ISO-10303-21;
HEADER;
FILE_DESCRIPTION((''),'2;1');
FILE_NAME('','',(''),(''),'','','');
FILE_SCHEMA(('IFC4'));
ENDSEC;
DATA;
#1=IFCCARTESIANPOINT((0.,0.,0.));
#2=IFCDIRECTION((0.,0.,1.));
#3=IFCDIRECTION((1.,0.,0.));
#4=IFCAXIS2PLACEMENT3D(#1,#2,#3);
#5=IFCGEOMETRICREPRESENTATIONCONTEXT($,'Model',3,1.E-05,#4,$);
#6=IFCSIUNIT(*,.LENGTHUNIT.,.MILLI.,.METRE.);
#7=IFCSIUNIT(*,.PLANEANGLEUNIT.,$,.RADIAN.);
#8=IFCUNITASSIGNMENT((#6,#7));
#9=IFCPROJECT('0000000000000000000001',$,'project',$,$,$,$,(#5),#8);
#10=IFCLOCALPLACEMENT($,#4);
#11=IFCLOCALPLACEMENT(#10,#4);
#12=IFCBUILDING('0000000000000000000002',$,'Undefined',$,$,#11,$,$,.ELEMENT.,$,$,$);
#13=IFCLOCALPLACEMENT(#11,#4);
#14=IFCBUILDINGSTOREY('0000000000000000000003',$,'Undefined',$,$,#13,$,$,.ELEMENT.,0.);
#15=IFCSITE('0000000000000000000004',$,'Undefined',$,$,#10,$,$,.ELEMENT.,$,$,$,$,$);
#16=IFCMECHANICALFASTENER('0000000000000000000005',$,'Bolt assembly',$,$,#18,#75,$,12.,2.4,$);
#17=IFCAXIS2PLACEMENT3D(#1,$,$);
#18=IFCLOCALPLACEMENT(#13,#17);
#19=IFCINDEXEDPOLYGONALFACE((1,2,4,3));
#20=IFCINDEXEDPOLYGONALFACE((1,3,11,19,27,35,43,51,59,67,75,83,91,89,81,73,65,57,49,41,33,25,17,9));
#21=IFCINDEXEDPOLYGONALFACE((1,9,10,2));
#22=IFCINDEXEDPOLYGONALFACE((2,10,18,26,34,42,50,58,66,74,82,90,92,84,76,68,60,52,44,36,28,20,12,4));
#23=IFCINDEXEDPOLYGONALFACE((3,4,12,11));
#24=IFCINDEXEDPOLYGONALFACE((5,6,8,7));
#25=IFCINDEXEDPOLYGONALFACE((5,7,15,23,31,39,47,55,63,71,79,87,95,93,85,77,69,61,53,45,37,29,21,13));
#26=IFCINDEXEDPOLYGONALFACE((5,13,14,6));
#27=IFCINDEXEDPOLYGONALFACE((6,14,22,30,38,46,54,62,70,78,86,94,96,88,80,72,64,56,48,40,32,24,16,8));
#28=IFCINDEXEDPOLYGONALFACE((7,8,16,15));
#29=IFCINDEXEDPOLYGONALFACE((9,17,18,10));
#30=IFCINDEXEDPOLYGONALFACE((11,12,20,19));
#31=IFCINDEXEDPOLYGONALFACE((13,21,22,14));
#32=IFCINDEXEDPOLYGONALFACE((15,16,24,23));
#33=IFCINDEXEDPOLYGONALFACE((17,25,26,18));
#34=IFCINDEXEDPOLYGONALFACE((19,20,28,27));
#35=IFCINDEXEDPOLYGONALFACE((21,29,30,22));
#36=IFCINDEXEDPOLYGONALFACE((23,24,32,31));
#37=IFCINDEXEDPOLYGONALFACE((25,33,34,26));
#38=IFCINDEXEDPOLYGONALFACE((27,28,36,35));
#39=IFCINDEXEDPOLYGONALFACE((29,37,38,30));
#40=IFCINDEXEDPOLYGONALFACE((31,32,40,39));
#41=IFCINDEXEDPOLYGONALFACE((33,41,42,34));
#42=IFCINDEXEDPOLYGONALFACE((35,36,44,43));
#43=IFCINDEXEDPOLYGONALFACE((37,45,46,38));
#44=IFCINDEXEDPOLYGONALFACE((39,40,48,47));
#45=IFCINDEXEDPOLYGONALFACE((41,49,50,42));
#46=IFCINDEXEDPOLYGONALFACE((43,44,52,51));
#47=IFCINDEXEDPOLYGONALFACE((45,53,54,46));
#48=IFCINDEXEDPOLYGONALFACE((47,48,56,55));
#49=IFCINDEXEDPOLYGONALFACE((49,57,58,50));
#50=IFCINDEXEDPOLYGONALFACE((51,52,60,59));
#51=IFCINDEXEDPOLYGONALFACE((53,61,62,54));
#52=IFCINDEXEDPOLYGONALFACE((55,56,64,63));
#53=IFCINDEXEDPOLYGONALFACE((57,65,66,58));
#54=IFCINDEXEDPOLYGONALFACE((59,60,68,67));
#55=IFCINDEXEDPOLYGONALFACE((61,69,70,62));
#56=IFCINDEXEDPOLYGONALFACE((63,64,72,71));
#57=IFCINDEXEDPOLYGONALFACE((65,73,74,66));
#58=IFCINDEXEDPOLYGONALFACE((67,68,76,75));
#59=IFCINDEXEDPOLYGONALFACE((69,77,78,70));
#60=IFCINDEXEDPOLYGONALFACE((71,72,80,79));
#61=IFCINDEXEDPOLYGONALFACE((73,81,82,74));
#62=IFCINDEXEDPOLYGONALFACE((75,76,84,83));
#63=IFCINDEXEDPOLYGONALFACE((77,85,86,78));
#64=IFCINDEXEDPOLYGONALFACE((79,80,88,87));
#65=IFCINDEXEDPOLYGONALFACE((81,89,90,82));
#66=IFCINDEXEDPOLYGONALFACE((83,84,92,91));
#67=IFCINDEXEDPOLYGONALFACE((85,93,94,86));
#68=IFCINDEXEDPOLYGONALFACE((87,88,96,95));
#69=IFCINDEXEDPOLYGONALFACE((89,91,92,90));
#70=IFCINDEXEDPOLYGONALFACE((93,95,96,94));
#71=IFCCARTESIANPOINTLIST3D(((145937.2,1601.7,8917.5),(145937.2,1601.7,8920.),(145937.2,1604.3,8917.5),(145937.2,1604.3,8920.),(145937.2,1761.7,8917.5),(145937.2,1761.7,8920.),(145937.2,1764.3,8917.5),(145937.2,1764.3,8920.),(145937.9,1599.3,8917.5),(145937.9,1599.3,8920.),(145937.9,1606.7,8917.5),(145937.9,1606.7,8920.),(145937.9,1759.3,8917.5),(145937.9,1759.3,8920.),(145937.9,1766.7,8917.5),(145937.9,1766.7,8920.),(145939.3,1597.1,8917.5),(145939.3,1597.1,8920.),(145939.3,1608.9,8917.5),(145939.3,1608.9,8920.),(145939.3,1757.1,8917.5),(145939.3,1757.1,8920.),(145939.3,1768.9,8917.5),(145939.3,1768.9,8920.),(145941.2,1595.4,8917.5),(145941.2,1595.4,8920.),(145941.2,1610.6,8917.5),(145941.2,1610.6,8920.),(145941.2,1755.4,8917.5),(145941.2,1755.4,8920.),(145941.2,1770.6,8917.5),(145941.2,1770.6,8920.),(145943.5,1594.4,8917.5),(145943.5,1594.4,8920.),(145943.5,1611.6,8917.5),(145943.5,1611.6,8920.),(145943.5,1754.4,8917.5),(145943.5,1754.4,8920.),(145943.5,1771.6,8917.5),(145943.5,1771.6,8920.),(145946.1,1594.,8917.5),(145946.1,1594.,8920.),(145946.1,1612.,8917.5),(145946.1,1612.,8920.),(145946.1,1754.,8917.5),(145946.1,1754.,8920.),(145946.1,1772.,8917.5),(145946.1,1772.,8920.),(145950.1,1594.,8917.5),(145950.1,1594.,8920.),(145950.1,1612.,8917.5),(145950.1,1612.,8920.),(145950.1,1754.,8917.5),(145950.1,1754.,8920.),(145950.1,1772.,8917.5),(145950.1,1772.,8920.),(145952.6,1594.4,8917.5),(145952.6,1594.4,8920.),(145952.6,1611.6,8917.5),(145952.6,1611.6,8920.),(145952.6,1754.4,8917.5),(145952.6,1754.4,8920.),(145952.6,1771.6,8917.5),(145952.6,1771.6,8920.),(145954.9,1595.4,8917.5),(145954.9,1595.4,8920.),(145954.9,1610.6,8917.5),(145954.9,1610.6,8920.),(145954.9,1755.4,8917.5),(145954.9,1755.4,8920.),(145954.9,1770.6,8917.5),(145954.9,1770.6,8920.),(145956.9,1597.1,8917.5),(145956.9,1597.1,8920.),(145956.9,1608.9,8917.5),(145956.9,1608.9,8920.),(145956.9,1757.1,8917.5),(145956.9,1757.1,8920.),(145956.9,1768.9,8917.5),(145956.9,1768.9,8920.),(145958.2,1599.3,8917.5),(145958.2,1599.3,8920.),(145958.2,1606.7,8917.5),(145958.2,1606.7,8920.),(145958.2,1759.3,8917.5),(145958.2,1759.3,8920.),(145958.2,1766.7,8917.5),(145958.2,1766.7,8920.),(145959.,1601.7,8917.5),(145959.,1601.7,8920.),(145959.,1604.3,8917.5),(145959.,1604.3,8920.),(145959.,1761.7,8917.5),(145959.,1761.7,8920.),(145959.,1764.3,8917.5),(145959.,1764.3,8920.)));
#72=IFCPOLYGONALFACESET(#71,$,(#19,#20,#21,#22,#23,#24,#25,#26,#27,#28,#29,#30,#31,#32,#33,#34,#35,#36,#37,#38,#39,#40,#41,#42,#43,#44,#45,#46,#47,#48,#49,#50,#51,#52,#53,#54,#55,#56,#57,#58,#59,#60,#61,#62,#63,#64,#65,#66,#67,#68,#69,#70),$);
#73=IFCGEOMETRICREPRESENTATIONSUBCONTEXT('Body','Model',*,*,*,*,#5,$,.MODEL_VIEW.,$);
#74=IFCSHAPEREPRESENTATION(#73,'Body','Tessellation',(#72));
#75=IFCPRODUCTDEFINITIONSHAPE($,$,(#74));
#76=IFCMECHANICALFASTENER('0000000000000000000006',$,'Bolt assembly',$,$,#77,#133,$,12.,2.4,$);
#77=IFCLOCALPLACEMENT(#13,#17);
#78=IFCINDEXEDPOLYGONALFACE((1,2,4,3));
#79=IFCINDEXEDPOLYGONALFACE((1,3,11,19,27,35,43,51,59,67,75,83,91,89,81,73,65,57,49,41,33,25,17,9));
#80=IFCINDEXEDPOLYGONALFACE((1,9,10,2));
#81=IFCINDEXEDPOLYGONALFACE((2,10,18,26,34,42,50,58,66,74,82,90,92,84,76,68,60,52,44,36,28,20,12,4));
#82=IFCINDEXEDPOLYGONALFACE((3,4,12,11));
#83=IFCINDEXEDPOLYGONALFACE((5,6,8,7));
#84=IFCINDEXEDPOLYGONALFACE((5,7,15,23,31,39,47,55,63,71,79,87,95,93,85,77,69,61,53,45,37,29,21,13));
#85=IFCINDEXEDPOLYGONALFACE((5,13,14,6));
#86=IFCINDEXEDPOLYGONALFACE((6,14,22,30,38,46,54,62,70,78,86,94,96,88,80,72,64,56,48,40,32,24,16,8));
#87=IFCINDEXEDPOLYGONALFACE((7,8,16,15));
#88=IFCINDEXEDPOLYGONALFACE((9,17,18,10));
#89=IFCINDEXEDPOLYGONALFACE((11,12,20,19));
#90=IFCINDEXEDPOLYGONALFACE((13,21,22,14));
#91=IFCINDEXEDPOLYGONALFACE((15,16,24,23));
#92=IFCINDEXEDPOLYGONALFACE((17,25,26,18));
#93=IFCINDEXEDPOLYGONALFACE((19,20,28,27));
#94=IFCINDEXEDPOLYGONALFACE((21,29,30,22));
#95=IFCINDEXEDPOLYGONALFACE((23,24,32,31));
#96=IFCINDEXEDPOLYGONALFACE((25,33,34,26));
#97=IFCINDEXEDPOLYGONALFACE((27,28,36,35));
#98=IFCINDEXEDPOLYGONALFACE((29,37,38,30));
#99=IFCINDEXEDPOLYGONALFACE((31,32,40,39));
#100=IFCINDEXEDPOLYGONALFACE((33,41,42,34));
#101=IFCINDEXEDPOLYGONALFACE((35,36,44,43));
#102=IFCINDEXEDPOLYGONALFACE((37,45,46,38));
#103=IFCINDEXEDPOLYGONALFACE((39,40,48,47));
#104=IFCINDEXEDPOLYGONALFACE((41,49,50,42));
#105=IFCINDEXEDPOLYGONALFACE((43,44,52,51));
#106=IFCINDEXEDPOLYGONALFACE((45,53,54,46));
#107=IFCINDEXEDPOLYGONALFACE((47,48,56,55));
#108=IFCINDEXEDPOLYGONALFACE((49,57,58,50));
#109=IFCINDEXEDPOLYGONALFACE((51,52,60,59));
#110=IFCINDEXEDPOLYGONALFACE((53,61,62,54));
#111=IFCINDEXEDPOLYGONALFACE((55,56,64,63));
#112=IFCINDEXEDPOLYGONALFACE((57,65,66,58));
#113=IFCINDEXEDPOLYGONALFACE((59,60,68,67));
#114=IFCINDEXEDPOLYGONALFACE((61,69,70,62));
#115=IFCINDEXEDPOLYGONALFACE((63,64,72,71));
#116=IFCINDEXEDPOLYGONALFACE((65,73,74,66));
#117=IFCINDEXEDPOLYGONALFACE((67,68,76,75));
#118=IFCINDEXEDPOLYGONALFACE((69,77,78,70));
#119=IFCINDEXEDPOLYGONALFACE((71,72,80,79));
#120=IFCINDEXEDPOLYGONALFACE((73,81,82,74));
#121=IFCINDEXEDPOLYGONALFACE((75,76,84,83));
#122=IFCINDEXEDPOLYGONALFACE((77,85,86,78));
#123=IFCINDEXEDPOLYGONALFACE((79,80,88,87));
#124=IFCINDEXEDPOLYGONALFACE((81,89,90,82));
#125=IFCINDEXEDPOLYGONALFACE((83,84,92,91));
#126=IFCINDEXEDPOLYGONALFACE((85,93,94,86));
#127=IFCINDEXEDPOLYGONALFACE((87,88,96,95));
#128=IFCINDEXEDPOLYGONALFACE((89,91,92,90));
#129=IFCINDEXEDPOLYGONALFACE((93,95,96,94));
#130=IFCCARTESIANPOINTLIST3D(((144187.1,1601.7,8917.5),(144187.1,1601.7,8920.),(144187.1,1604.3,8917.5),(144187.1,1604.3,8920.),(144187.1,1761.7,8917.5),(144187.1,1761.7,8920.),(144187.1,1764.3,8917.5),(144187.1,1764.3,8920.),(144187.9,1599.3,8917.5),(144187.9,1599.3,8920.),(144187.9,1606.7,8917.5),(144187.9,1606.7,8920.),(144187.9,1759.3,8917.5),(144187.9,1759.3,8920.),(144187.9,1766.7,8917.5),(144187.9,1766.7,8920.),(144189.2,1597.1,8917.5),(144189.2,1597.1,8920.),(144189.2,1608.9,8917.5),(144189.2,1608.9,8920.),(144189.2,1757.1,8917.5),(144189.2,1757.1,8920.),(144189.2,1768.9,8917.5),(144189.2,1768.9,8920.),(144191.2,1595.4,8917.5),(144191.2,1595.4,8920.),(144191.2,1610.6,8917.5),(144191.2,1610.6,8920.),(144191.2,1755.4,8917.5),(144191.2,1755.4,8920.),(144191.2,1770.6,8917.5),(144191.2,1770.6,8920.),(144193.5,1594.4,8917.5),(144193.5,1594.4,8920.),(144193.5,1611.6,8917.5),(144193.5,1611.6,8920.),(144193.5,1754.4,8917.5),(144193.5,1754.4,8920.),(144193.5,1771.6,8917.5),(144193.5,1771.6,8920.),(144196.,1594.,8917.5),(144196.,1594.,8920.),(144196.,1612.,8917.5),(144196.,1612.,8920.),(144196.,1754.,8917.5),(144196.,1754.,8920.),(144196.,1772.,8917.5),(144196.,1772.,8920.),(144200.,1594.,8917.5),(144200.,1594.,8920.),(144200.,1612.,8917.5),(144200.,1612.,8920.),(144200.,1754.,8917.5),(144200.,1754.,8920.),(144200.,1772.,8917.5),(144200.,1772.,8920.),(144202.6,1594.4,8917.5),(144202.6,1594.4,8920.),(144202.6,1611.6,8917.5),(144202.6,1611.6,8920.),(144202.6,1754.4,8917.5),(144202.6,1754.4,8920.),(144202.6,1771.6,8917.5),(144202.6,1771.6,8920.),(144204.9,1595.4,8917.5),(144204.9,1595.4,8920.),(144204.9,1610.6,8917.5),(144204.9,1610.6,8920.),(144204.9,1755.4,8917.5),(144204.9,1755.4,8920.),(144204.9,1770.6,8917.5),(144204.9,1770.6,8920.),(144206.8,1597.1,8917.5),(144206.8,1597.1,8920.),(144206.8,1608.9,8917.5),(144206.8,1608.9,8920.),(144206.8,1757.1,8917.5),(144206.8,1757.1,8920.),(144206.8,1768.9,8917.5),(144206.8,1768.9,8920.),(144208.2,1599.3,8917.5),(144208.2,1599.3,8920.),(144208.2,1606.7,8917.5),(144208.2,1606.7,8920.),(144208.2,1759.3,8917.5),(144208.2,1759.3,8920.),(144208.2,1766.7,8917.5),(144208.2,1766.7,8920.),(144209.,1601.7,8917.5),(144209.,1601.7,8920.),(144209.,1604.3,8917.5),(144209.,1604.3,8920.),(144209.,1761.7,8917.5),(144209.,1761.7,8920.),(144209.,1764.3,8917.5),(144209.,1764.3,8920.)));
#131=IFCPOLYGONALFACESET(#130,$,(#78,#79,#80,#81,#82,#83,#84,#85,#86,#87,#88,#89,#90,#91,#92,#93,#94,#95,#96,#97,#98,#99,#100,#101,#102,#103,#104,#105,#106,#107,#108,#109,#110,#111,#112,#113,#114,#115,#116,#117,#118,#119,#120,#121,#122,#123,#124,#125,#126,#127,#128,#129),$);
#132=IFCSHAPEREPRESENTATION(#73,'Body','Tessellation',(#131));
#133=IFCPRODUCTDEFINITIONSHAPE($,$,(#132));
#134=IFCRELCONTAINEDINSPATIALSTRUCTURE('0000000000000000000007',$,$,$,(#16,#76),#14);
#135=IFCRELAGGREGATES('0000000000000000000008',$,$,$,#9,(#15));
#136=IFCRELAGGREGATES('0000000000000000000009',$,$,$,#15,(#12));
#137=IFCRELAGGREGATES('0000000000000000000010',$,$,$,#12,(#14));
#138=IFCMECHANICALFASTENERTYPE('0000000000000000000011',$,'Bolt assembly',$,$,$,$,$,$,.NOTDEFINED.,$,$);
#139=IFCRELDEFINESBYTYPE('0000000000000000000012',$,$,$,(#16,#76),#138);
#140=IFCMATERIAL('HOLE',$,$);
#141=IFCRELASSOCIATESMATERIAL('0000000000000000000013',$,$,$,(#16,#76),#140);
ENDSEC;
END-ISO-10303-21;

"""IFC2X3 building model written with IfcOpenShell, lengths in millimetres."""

from ifc_helpers import new_model, si_unit, frame, frame_2d, origin_with_axes, place, context, subcontext, project, spatial, polyline, circle_curve, parameter, trimmed, segment, composite_curve, outline, extrude, source, transform, mapped, material, type_object, element, save


model = new_model("IFC2X3")

# Units and contexts
model_context = context("Model", 3, precision=1e-05, world=origin_with_axes())
body_context = subcontext(model_context, "Body", "Model", "MODEL_VIEW")
ifc_project = project(units=[si_unit("LENGTHUNIT", "METRE", prefix="MILLI"), si_unit("PLANEANGLEUNIT", "RADIAN")], contexts=[model_context])

# Site, building, storey
site_placement = place(None, origin_with_axes())
site = spatial("IfcSite", under=ifc_project, at=site_placement, Name="Undefined", CompositionType="ELEMENT")
building_placement = place(site_placement, origin_with_axes())
building = spatial("IfcBuilding", under=site, at=building_placement, Name="Undefined", CompositionType="ELEMENT")
storey_placement = place(building_placement, origin_with_axes())
storey = spatial("IfcBuildingStorey", under=building, at=storey_placement, Name="Undefined", CompositionType="ELEMENT", Elevation=0.0)

# Mechanical fasteners
mechanical_fastener_type = type_object("IfcMechanicalFastenerType", Name="Bolt assembly")
ifc_material_1 = material(Name="HOLE")
shared_shape_1 = source(origin_with_axes(), body_context, "Body", "SweptSolid", [
    extrude(outline(composite_curve([segment(polyline([(-2.0, 9.0), (2.0, 9.0)]), True, "CONTINUOUS"), segment(trimmed(circle_curve(frame_2d((2.0, 0.0), x_axis=(0.0, 1.0)), 9.0), [parameter(0.0)], [parameter(3.141593)], False, "PARAMETER"), True, "CONTINUOUS"), segment(polyline([(2.0, -9.0), (-2.0, -9.0)]), True, "CONTINUOUS"), segment(trimmed(circle_curve(frame_2d((-2.0, 0.0), x_axis=(0.0, -1.0)), 9.0), [parameter(0.0)], [parameter(3.141593)], False, "PARAMETER"), True, "DISCONTINUOUS")], self_intersect=False)), frame((0.0, -2.4, 0.0), z_axis=(0.0, 1.0, 0.0), x_axis=(1.0, 0.0, 0.0)), (0.0, 0.0, 1.0), 2.5),
])
mechanical_fastener_1_placement = place(storey_placement, frame((145948.1, 1683.0, 8917.6), z_axis=(0.0, -1.0, 0.0), x_axis=(-1.0, 0.0, 0.0)))
element("IfcMechanicalFastener", 1, at=mechanical_fastener_1_placement, inside=storey, type_object=mechanical_fastener_type, material=ifc_material_1, Name="Bolt assembly", NominalDiameter=12.0, NominalLength=2.4, context=body_context, shape_type="MappedRepresentation", body=[
    mapped(shared_shape_1, transform((0.0, 0.0, -80.0))),
    mapped(shared_shape_1, transform((0.0, 0.0, 80.0))),
])
shared_shape_2 = source(origin_with_axes(), body_context, "Body", "SweptSolid", [
    extrude(outline(composite_curve([segment(polyline([(-2.0, 9.0), (2.0, 9.0)]), True, "CONTINUOUS"), segment(trimmed(circle_curve(frame_2d((2.0, 0.0), x_axis=(0.0, 1.0)), 9.0), [parameter(0.0)], [parameter(3.141593)], False, "PARAMETER"), True, "CONTINUOUS"), segment(polyline([(2.0, -9.0), (-2.0, -9.0)]), True, "CONTINUOUS"), segment(trimmed(circle_curve(frame_2d((-2.0, 0.0), x_axis=(0.0, -1.0)), 9.0), [parameter(0.0)], [parameter(3.141593)], False, "PARAMETER"), True, "DISCONTINUOUS")], self_intersect=False)), frame((0.0, -2.4, 0.0), z_axis=(0.0, 1.0, 0.0), x_axis=(1.0, 0.0, 0.0)), (0.0, 0.0, 1.0), 2.5),
])
mechanical_fastener_2_placement = place(storey_placement, frame((144198.0, 1683.0, 8917.6), z_axis=(0.0, -1.0, 0.0), x_axis=(-1.0, 0.0, 0.0)))
element("IfcMechanicalFastener", 2, at=mechanical_fastener_2_placement, inside=storey, type_object=mechanical_fastener_type, material=ifc_material_1, Name="Bolt assembly", NominalDiameter=12.0, NominalLength=2.4, context=body_context, shape_type="MappedRepresentation", body=[
    mapped(shared_shape_2, transform((0.0, 0.0, -80.0))),
    mapped(shared_shape_2, transform((0.0, 0.0, 80.0))),
])

save(model, "model.ifc")
